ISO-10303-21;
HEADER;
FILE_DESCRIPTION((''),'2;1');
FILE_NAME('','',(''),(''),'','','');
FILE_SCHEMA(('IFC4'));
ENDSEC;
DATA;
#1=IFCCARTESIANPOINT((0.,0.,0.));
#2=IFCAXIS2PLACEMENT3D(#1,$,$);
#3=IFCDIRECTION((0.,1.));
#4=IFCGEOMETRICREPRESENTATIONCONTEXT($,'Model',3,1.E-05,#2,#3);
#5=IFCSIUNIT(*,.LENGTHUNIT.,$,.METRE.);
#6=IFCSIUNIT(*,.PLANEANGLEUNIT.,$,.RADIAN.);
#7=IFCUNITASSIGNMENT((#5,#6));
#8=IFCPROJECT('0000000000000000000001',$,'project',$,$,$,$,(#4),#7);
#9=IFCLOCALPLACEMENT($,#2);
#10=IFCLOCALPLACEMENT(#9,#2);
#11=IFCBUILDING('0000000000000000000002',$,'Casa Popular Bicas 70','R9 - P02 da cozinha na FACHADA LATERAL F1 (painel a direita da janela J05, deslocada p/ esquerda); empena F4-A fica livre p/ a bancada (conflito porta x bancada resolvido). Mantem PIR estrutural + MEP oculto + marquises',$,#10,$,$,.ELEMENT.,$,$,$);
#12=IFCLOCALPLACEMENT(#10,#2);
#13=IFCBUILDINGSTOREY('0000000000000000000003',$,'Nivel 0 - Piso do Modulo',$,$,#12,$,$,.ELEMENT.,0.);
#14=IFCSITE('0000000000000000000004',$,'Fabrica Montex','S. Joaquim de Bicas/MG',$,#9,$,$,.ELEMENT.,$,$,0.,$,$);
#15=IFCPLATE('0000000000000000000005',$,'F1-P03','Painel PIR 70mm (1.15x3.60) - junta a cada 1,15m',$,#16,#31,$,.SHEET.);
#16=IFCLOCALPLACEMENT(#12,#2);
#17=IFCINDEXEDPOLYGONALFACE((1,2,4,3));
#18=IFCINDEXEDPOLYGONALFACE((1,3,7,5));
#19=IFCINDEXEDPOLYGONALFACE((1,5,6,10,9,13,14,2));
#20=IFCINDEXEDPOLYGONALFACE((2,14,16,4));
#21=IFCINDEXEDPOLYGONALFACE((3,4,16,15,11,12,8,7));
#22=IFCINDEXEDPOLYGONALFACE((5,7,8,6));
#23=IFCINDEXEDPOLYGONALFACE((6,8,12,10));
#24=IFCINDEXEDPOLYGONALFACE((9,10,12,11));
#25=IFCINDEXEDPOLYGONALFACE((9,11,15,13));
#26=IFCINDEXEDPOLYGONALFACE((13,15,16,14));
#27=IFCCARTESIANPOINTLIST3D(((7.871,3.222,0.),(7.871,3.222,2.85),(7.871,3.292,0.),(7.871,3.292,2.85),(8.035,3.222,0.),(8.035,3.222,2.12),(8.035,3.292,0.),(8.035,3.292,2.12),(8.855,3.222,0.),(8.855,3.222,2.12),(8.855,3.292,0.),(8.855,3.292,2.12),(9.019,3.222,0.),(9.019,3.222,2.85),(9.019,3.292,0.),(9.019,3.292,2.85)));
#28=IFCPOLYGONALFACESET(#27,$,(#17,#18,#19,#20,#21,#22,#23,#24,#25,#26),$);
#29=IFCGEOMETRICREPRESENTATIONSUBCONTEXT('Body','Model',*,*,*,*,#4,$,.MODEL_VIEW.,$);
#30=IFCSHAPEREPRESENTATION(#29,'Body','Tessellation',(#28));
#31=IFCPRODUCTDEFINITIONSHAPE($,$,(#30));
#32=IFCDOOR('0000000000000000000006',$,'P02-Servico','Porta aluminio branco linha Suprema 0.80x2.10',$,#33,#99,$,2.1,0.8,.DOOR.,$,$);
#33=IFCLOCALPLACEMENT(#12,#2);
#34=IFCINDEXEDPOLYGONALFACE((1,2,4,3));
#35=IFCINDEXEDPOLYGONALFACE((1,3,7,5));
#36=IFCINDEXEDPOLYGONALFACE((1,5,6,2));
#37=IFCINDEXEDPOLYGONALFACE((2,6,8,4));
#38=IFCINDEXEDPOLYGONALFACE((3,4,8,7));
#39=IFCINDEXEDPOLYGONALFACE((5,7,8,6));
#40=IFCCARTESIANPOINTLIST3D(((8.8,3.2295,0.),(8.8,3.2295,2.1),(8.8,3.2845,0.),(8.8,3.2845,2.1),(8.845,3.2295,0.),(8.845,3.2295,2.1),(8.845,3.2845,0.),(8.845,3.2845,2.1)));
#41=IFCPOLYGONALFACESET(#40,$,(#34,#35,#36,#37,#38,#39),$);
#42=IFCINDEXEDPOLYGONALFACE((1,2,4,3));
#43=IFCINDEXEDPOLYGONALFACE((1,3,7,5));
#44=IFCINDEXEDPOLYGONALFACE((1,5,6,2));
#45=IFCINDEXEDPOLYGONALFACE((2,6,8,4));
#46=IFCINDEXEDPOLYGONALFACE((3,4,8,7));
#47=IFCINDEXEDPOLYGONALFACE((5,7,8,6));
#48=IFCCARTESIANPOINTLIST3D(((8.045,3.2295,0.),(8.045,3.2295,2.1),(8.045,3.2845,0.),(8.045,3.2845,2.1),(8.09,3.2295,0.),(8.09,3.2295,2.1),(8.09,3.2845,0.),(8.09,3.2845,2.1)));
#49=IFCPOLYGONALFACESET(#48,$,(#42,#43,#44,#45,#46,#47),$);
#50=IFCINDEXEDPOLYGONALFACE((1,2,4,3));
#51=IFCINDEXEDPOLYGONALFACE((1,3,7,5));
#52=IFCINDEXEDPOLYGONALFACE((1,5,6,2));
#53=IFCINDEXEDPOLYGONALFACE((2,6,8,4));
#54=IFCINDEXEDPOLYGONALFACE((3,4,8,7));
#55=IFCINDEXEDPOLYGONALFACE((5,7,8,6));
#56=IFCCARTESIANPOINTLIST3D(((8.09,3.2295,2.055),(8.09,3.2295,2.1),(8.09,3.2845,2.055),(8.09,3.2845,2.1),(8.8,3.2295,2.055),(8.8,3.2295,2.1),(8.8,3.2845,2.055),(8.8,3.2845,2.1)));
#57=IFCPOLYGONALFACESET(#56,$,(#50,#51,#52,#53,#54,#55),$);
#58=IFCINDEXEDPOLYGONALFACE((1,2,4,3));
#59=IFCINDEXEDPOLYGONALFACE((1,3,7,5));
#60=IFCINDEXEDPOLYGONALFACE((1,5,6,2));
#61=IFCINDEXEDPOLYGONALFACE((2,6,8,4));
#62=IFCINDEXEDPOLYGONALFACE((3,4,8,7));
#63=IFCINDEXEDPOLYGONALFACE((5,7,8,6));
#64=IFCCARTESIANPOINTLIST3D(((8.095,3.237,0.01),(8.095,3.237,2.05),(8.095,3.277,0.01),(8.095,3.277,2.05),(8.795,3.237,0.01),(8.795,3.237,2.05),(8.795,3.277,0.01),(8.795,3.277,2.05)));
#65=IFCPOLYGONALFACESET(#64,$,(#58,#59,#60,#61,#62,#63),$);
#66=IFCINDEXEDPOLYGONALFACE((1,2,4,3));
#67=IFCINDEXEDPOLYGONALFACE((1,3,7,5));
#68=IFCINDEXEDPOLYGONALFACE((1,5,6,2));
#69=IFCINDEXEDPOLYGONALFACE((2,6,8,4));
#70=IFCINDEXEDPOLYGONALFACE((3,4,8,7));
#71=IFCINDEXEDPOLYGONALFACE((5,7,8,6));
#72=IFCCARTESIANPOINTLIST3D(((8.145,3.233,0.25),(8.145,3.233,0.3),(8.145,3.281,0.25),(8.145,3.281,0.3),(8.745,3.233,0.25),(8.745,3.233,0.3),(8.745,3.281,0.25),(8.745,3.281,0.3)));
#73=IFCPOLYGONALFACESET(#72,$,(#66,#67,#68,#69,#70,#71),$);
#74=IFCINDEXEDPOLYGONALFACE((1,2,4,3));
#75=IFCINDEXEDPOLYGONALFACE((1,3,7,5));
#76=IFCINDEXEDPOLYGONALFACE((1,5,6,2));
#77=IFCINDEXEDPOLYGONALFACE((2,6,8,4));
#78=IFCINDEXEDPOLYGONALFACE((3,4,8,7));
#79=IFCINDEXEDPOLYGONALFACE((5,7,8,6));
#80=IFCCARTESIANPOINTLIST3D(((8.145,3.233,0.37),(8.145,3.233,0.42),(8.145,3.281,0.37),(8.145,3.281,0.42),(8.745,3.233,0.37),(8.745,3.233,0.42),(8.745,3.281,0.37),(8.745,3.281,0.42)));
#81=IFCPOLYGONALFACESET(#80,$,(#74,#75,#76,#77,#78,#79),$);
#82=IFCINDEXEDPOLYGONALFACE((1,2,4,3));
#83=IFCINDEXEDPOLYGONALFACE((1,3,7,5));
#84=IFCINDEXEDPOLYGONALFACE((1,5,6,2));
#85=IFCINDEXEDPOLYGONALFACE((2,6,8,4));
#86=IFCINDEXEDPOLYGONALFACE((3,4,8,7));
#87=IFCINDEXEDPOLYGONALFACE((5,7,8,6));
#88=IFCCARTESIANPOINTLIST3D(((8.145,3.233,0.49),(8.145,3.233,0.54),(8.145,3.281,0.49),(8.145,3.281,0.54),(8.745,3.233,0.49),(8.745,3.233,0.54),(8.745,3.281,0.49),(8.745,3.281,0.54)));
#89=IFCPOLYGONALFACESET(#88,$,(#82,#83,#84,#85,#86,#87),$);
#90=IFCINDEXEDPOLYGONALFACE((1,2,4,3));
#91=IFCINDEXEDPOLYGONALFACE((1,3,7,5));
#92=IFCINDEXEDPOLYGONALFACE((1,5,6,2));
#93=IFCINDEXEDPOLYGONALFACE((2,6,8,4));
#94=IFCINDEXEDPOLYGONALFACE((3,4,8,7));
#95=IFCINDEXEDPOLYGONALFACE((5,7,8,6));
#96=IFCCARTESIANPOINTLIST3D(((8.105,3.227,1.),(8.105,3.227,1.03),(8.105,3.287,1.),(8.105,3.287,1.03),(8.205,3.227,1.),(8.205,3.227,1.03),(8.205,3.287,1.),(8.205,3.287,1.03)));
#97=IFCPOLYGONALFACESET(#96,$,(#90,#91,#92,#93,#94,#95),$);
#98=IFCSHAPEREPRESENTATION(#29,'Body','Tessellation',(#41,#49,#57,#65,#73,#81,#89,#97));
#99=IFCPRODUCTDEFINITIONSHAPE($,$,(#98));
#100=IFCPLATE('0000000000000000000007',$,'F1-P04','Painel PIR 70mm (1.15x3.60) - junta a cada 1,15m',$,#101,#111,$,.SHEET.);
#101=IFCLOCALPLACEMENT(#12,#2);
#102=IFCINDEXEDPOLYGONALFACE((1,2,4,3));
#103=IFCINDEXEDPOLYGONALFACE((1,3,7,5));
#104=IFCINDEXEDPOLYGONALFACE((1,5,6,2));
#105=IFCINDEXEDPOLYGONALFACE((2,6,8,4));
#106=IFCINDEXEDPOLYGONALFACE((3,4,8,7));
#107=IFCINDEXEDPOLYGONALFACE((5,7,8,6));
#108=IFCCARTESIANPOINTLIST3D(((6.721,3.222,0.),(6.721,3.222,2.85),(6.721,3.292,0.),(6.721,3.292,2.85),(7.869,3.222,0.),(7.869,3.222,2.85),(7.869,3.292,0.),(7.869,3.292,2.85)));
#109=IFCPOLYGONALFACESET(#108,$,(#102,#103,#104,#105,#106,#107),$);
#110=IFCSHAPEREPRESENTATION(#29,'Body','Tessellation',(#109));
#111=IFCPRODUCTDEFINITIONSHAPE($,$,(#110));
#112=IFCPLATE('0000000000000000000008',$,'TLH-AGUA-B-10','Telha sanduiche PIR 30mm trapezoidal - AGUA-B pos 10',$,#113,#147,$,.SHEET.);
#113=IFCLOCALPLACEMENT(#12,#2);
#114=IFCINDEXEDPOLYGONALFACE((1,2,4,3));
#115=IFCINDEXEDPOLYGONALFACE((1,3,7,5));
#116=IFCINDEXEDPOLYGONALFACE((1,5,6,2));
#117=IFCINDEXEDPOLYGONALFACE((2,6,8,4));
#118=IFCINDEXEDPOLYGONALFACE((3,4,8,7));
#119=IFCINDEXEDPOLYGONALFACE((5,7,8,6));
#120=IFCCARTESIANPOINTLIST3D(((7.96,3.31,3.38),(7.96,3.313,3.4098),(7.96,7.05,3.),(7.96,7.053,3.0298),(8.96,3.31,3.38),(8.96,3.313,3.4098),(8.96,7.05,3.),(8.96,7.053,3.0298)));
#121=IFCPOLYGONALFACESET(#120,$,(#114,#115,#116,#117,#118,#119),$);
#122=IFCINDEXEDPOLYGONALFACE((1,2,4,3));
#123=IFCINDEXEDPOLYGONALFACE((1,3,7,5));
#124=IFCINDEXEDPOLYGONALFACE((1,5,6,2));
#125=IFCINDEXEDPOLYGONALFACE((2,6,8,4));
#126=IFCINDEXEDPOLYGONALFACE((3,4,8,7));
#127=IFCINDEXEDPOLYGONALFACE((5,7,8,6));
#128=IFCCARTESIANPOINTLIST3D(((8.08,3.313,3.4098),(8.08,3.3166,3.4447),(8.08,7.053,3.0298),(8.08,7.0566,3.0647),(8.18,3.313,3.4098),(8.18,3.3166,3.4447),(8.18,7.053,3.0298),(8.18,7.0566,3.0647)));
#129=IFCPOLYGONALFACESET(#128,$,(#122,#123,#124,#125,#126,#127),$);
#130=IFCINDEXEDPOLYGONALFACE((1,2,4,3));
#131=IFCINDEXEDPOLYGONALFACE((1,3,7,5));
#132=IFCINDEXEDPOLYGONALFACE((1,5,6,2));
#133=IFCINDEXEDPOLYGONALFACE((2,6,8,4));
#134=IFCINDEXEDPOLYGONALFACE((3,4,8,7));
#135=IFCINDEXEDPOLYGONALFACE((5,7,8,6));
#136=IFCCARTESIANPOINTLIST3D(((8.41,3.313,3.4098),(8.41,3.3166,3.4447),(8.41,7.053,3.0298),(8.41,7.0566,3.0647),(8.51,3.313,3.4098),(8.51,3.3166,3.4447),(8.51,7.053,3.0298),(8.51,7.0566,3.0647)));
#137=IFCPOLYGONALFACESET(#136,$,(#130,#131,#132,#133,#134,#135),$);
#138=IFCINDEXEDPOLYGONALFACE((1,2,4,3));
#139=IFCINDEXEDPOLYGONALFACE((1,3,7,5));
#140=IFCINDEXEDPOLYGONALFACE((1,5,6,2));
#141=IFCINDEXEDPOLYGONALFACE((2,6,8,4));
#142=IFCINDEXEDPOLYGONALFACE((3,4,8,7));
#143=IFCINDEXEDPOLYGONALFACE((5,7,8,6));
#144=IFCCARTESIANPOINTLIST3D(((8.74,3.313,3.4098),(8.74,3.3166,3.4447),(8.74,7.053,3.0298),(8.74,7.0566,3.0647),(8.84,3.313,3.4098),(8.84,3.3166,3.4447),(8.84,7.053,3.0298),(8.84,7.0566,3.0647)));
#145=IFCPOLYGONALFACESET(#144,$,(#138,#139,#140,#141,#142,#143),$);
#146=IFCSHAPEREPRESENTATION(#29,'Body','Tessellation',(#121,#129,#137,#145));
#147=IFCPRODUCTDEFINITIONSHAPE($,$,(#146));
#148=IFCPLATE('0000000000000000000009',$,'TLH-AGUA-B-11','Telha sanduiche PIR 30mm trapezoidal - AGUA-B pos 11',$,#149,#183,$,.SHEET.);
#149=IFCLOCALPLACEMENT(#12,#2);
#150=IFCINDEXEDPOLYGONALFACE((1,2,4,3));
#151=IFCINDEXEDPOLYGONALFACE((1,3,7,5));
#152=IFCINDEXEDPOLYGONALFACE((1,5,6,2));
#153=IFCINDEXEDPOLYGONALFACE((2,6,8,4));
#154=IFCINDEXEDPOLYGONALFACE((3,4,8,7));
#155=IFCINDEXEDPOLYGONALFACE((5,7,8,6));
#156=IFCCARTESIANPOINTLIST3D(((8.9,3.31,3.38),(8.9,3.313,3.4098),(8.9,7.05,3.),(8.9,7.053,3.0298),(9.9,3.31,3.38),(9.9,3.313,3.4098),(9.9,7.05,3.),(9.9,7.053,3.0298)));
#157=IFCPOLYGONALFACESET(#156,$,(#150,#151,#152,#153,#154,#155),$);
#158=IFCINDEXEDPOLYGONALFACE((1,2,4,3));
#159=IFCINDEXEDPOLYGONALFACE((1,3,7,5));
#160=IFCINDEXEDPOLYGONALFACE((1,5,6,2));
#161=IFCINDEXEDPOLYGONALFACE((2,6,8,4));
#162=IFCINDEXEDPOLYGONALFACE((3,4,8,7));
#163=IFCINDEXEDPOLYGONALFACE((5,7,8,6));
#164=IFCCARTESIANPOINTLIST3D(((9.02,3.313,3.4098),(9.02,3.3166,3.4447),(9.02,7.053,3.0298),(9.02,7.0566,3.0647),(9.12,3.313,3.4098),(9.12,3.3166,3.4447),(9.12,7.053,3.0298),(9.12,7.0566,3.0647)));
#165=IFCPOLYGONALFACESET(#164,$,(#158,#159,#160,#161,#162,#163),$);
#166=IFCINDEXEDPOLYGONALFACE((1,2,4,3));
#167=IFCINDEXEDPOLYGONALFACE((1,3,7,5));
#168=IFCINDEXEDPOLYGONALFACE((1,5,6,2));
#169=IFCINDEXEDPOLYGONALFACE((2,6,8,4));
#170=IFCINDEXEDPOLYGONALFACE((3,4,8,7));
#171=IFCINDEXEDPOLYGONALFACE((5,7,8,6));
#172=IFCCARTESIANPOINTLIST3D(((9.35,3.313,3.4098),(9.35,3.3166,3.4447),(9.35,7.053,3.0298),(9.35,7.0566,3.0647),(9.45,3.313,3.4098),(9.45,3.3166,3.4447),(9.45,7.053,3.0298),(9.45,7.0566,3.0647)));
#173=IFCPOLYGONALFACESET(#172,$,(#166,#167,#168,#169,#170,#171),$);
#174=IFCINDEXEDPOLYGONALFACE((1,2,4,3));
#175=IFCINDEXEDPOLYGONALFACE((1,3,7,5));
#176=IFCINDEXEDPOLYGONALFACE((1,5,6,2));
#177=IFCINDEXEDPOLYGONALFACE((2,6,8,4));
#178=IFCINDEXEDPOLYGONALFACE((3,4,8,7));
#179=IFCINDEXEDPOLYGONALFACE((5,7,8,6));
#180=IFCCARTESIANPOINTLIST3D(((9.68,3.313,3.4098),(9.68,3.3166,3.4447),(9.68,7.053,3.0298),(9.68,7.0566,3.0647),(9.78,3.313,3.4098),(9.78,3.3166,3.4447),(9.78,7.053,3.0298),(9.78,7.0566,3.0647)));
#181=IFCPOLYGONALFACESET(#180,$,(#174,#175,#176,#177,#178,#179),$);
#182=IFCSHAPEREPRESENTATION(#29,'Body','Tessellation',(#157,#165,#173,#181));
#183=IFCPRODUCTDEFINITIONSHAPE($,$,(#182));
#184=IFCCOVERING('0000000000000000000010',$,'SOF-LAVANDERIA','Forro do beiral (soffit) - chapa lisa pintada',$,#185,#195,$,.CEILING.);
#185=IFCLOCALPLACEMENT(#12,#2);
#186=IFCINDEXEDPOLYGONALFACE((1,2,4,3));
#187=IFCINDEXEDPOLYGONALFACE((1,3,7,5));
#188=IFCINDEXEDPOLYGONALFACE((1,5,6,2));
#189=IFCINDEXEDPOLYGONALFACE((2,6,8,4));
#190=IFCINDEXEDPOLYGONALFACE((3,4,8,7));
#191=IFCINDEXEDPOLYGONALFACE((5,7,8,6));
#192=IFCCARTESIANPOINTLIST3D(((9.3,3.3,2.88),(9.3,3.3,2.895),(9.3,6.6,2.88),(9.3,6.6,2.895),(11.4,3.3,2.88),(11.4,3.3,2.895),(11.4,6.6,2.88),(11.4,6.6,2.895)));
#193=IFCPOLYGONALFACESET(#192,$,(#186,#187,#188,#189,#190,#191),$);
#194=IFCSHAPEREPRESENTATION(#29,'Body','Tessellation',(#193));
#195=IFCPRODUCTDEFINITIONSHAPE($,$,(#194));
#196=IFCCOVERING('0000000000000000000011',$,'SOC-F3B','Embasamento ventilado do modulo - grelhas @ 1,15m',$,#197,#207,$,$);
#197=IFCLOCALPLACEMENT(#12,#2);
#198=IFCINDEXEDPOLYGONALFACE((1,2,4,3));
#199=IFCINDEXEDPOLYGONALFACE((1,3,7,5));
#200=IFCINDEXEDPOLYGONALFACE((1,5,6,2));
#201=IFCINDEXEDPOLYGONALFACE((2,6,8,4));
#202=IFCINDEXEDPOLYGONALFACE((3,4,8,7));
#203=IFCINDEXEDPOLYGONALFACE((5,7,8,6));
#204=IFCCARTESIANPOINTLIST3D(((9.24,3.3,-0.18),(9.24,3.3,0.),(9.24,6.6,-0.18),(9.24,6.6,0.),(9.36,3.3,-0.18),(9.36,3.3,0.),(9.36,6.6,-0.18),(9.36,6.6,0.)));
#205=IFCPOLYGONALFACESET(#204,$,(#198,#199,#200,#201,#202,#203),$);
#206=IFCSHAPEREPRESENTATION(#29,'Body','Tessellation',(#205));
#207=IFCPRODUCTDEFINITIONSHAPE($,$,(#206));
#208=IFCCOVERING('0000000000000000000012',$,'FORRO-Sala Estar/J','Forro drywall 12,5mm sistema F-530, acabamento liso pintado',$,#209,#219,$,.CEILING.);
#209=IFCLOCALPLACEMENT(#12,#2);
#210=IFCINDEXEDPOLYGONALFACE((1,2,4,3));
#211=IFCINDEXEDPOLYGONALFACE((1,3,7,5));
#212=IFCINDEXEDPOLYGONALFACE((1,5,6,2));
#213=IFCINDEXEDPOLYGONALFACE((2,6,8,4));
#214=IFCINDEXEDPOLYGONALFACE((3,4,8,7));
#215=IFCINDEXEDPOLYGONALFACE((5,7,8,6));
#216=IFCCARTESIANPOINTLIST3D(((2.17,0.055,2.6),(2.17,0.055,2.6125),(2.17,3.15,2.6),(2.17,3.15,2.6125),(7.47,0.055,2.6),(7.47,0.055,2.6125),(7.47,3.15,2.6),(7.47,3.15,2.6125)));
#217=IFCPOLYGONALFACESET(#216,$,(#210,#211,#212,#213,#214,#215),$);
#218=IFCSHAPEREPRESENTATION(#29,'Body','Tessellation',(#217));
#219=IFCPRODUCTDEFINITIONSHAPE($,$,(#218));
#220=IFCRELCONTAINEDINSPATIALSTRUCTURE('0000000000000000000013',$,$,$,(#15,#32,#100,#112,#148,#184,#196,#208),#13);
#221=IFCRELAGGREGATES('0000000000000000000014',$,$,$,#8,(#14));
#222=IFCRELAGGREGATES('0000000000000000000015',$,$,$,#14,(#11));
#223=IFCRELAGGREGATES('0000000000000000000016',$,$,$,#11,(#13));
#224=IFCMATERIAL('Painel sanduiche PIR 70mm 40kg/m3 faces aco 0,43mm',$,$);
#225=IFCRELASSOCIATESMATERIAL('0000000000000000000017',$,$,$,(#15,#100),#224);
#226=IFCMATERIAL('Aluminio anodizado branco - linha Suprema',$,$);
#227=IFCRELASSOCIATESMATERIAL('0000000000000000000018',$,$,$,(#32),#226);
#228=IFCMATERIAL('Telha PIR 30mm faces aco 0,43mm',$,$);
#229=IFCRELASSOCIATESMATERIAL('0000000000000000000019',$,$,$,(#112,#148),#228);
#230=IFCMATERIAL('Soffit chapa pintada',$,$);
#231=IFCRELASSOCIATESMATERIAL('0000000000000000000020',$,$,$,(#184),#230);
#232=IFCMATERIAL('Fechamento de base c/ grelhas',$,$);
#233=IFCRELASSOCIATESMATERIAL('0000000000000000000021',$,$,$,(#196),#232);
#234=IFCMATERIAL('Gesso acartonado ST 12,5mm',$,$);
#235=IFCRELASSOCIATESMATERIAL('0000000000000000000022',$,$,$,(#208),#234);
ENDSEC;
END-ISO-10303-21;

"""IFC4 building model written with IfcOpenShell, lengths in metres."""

from ifc_helpers import new_model, si_unit, direction, frame, frame_2d, origin, place, context, subcontext, project, spatial, rectangle, extrude, material, element, fill, save


model = new_model("IFC4")

# Units and contexts
model_context = context("Model", 3, precision=1e-05, world=origin(), true_north=direction((0.0, 1.0)))
body_context = subcontext(model_context, "Body", "Model", "MODEL_VIEW")
ifc_project = project(units=[si_unit("LENGTHUNIT", "METRE"), si_unit("PLANEANGLEUNIT", "RADIAN")], contexts=[model_context])

# Site, building, storey
site_placement = place(None, origin())
site = spatial("IfcSite", under=ifc_project, at=site_placement, Name="Fabrica Montex", Description="S. Joaquim de Bicas/MG", CompositionType="ELEMENT", RefElevation=0.0)
building_placement = place(site_placement, origin())
building = spatial("IfcBuilding", under=site, at=building_placement, Name="Casa Popular Bicas 70", Description="R9 - P02 da cozinha na FACHADA LATERAL F1 (painel a direita da janela J05, deslocada p/ esquerda); empena F4-A fica livre p/ a bancada (conflito porta x bancada resolvido). Mantem PIR estrutural + MEP oculto + marquises", CompositionType="ELEMENT")
storey_placement = place(building_placement, origin())
storey = spatial("IfcBuildingStorey", under=building, at=storey_placement, Name="Nivel 0 - Piso do Modulo", CompositionType="ELEMENT", Elevation=0.0)

# Shared definitions
ifc_material_1 = material(Name="Aluminio anodizado branco - linha Suprema")

# Plate, opening, door
ifc_material_2 = material(Name="Painel sanduiche PIR 70mm 40kg/m3 faces aco 0,43mm")
plate_1_placement = place(None, frame((9.019, 3.257, 0.0), z_axis=(0.0, 0.0, 1.0), x_axis=(-1.0, 0.0, 0.0)))
plate_1 = element("IfcPlate", 1, at=plate_1_placement, inside=storey, material=ifc_material_2, Name="F1-P03", Description="Painel PIR 70mm (1.15x3.60) - junta a cada 1,15m", PredefinedType="SHEET", context=body_context, shape_type="SweptSolid", body=[
    extrude(rectangle(XDim=1.148, YDim=0.07, at=frame_2d((0.574, 0.0))), origin(), (0.0, 0.0, 1.0), 2.85),
])
opening_placement = place(None, frame((8.845, 3.257, 0.0), z_axis=(0.0, 0.0, 1.0), x_axis=(-1.0, 0.0, 0.0)))
opening = element("IfcOpeningElement", 2, at=opening_placement, cuts=plate_1, PredefinedType="OPENING", context=body_context, shape_type="SweptSolid", body=[
    extrude(rectangle(XDim=0.82, YDim=0.3, at=frame_2d((0.4, 0.0))), origin(), (0.0, 0.0, 1.0), 2.12),
])
door_placement = place(None, frame((8.845, 3.257, 0.0), z_axis=(0.0, 0.0, 1.0), x_axis=(-1.0, 0.0, 0.0)))
door = element("IfcDoor", 3, at=door_placement, inside=storey, material=ifc_material_1, Name="P02-Servico", Description="Porta aluminio branco linha Suprema 0.80x2.10", OverallHeight=2.1, OverallWidth=0.8, PredefinedType="DOOR", context=body_context, shape_type="SweptSolid", body=[
    extrude(rectangle(XDim=0.045, YDim=0.055, at=frame_2d((0.0225, 0.0))), origin(), (0.0, 0.0, 1.0), 2.1),
    extrude(rectangle(XDim=0.045, YDim=0.055, at=frame_2d((0.7775, 0.0))), origin(), (0.0, 0.0, 1.0), 2.1),
    extrude(rectangle(XDim=0.71, YDim=0.055, at=frame_2d((0.4, 0.0))), frame((0.0, 0.0, 2.055)), (0.0, 0.0, 1.0), 0.045),
    extrude(rectangle(XDim=0.7, YDim=0.04, at=frame_2d((0.4, 0.0))), frame((0.0, 0.0, 0.01)), (0.0, 0.0, 1.0), 2.04),
    extrude(rectangle(XDim=0.6, YDim=0.048, at=frame_2d((0.4, 0.0))), frame((0.0, 0.0, 0.25)), (0.0, 0.0, 1.0), 0.05),
    extrude(rectangle(XDim=0.6, YDim=0.048, at=frame_2d((0.4, 0.0))), frame((0.0, 0.0, 0.37)), (0.0, 0.0, 1.0), 0.05),
    extrude(rectangle(XDim=0.6, YDim=0.048, at=frame_2d((0.4, 0.0))), frame((0.0, 0.0, 0.49)), (0.0, 0.0, 1.0), 0.05),
    extrude(rectangle(XDim=0.1, YDim=0.06, at=frame_2d((0.69, 0.0))), frame((0.0, 0.0, 1.0)), (0.0, 0.0, 1.0), 0.03),
])
fill(opening, door)

# Plates
plate_2_placement = place(None, frame((7.869, 3.257, 0.0), z_axis=(0.0, 0.0, 1.0), x_axis=(-1.0, 0.0, 0.0)))
element("IfcPlate", 4, at=plate_2_placement, inside=storey, material=ifc_material_2, Name="F1-P04", Description="Painel PIR 70mm (1.15x3.60) - junta a cada 1,15m", PredefinedType="SHEET", context=body_context, shape_type="SweptSolid", body=[
    extrude(rectangle(XDim=1.148, YDim=0.07, at=frame_2d((0.574, 0.0))), origin(), (0.0, 0.0, 1.0), 2.85),
])
ifc_material_3 = material(Name="Telha PIR 30mm faces aco 0,43mm")
for number, where, z_axis, x_axis, name, description in (
    (5, (7.96, 3.31, 3.38), (0.0, 0.101084, 0.994878), (1.0, 0.0, 0.0), "TLH-AGUA-B-10", "Telha sanduiche PIR 30mm trapezoidal - AGUA-B pos 10"),
    (6, (8.9, 3.31, 3.38), (0.0, 0.101084, 0.994878), (1.0, 0.0, 0.0), "TLH-AGUA-B-11", "Telha sanduiche PIR 30mm trapezoidal - AGUA-B pos 11"),
):
    element("IfcPlate", number, at=place(storey_placement, frame(where, z_axis=z_axis, x_axis=x_axis)), inside=storey, material=ifc_material_3, Name=name, Description=description, PredefinedType="SHEET", context=body_context, shape_type="SweptSolid", body=[
        extrude(rectangle(XDim=1.0, YDim=3.7593, at=frame_2d((0.5, 1.8796))), origin(), (0.0, 0.0, 1.0), 0.03),
        extrude(rectangle(XDim=0.1, YDim=3.7593, at=frame_2d((0.17, 1.8796))), frame((0.0, 0.0, 0.03)), (0.0, 0.0, 1.0), 0.035),
        extrude(rectangle(XDim=0.1, YDim=3.7593, at=frame_2d((0.5, 1.8796))), frame((0.0, 0.0, 0.03)), (0.0, 0.0, 1.0), 0.035),
        extrude(rectangle(XDim=0.1, YDim=3.7593, at=frame_2d((0.83, 1.8796))), frame((0.0, 0.0, 0.03)), (0.0, 0.0, 1.0), 0.035),
    ])

# Coverings
ifc_material_4 = material(Name="Soffit chapa pintada")
covering_1_placement = place(storey_placement, frame((9.3, 3.3, 2.88)))
element("IfcCovering", 7, at=covering_1_placement, inside=storey, material=ifc_material_4, Name="SOF-LAVANDERIA", Description="Forro do beiral (soffit) - chapa lisa pintada", PredefinedType="CEILING", context=body_context, shape_type="SweptSolid", body=[
    extrude(rectangle(XDim=2.1, YDim=3.3, at=frame_2d((1.05, 1.65))), origin(), (0.0, 0.0, 1.0), 0.015),
])
ifc_material_5 = material(Name="Fechamento de base c/ grelhas")
covering_2_placement = place(storey_placement, frame((9.3, 3.3, -0.18), x_axis=(0.0, 1.0, 0.0)))
element("IfcCovering", 8, at=covering_2_placement, inside=storey, material=ifc_material_5, Name="SOC-F3B", Description="Embasamento ventilado do modulo - grelhas @ 1,15m", context=body_context, shape_type="SweptSolid", body=[
    extrude(rectangle(XDim=3.3, YDim=0.12, at=frame_2d((1.65, 0.0))), origin(), (0.0, 0.0, 1.0), 0.18),
])
ifc_material_6 = material(Name="Gesso acartonado ST 12,5mm")
covering_3_placement = place(None, frame((7.47, 3.15, 2.6), z_axis=(0.0, 0.0, 1.0), x_axis=(-1.0, 0.0, 0.0)))
element("IfcCovering", 9, at=covering_3_placement, inside=storey, material=ifc_material_6, Name="FORRO-Sala Estar/J", Description="Forro drywall 12,5mm sistema F-530, acabamento liso pintado", PredefinedType="CEILING", context=body_context, shape_type="SweptSolid", body=[
    extrude(rectangle(XDim=5.3, YDim=3.095, at=frame_2d((2.65, 1.5475))), origin(), (0.0, 0.0, 1.0), 0.0125),
])

save(model, "model.ifc")
